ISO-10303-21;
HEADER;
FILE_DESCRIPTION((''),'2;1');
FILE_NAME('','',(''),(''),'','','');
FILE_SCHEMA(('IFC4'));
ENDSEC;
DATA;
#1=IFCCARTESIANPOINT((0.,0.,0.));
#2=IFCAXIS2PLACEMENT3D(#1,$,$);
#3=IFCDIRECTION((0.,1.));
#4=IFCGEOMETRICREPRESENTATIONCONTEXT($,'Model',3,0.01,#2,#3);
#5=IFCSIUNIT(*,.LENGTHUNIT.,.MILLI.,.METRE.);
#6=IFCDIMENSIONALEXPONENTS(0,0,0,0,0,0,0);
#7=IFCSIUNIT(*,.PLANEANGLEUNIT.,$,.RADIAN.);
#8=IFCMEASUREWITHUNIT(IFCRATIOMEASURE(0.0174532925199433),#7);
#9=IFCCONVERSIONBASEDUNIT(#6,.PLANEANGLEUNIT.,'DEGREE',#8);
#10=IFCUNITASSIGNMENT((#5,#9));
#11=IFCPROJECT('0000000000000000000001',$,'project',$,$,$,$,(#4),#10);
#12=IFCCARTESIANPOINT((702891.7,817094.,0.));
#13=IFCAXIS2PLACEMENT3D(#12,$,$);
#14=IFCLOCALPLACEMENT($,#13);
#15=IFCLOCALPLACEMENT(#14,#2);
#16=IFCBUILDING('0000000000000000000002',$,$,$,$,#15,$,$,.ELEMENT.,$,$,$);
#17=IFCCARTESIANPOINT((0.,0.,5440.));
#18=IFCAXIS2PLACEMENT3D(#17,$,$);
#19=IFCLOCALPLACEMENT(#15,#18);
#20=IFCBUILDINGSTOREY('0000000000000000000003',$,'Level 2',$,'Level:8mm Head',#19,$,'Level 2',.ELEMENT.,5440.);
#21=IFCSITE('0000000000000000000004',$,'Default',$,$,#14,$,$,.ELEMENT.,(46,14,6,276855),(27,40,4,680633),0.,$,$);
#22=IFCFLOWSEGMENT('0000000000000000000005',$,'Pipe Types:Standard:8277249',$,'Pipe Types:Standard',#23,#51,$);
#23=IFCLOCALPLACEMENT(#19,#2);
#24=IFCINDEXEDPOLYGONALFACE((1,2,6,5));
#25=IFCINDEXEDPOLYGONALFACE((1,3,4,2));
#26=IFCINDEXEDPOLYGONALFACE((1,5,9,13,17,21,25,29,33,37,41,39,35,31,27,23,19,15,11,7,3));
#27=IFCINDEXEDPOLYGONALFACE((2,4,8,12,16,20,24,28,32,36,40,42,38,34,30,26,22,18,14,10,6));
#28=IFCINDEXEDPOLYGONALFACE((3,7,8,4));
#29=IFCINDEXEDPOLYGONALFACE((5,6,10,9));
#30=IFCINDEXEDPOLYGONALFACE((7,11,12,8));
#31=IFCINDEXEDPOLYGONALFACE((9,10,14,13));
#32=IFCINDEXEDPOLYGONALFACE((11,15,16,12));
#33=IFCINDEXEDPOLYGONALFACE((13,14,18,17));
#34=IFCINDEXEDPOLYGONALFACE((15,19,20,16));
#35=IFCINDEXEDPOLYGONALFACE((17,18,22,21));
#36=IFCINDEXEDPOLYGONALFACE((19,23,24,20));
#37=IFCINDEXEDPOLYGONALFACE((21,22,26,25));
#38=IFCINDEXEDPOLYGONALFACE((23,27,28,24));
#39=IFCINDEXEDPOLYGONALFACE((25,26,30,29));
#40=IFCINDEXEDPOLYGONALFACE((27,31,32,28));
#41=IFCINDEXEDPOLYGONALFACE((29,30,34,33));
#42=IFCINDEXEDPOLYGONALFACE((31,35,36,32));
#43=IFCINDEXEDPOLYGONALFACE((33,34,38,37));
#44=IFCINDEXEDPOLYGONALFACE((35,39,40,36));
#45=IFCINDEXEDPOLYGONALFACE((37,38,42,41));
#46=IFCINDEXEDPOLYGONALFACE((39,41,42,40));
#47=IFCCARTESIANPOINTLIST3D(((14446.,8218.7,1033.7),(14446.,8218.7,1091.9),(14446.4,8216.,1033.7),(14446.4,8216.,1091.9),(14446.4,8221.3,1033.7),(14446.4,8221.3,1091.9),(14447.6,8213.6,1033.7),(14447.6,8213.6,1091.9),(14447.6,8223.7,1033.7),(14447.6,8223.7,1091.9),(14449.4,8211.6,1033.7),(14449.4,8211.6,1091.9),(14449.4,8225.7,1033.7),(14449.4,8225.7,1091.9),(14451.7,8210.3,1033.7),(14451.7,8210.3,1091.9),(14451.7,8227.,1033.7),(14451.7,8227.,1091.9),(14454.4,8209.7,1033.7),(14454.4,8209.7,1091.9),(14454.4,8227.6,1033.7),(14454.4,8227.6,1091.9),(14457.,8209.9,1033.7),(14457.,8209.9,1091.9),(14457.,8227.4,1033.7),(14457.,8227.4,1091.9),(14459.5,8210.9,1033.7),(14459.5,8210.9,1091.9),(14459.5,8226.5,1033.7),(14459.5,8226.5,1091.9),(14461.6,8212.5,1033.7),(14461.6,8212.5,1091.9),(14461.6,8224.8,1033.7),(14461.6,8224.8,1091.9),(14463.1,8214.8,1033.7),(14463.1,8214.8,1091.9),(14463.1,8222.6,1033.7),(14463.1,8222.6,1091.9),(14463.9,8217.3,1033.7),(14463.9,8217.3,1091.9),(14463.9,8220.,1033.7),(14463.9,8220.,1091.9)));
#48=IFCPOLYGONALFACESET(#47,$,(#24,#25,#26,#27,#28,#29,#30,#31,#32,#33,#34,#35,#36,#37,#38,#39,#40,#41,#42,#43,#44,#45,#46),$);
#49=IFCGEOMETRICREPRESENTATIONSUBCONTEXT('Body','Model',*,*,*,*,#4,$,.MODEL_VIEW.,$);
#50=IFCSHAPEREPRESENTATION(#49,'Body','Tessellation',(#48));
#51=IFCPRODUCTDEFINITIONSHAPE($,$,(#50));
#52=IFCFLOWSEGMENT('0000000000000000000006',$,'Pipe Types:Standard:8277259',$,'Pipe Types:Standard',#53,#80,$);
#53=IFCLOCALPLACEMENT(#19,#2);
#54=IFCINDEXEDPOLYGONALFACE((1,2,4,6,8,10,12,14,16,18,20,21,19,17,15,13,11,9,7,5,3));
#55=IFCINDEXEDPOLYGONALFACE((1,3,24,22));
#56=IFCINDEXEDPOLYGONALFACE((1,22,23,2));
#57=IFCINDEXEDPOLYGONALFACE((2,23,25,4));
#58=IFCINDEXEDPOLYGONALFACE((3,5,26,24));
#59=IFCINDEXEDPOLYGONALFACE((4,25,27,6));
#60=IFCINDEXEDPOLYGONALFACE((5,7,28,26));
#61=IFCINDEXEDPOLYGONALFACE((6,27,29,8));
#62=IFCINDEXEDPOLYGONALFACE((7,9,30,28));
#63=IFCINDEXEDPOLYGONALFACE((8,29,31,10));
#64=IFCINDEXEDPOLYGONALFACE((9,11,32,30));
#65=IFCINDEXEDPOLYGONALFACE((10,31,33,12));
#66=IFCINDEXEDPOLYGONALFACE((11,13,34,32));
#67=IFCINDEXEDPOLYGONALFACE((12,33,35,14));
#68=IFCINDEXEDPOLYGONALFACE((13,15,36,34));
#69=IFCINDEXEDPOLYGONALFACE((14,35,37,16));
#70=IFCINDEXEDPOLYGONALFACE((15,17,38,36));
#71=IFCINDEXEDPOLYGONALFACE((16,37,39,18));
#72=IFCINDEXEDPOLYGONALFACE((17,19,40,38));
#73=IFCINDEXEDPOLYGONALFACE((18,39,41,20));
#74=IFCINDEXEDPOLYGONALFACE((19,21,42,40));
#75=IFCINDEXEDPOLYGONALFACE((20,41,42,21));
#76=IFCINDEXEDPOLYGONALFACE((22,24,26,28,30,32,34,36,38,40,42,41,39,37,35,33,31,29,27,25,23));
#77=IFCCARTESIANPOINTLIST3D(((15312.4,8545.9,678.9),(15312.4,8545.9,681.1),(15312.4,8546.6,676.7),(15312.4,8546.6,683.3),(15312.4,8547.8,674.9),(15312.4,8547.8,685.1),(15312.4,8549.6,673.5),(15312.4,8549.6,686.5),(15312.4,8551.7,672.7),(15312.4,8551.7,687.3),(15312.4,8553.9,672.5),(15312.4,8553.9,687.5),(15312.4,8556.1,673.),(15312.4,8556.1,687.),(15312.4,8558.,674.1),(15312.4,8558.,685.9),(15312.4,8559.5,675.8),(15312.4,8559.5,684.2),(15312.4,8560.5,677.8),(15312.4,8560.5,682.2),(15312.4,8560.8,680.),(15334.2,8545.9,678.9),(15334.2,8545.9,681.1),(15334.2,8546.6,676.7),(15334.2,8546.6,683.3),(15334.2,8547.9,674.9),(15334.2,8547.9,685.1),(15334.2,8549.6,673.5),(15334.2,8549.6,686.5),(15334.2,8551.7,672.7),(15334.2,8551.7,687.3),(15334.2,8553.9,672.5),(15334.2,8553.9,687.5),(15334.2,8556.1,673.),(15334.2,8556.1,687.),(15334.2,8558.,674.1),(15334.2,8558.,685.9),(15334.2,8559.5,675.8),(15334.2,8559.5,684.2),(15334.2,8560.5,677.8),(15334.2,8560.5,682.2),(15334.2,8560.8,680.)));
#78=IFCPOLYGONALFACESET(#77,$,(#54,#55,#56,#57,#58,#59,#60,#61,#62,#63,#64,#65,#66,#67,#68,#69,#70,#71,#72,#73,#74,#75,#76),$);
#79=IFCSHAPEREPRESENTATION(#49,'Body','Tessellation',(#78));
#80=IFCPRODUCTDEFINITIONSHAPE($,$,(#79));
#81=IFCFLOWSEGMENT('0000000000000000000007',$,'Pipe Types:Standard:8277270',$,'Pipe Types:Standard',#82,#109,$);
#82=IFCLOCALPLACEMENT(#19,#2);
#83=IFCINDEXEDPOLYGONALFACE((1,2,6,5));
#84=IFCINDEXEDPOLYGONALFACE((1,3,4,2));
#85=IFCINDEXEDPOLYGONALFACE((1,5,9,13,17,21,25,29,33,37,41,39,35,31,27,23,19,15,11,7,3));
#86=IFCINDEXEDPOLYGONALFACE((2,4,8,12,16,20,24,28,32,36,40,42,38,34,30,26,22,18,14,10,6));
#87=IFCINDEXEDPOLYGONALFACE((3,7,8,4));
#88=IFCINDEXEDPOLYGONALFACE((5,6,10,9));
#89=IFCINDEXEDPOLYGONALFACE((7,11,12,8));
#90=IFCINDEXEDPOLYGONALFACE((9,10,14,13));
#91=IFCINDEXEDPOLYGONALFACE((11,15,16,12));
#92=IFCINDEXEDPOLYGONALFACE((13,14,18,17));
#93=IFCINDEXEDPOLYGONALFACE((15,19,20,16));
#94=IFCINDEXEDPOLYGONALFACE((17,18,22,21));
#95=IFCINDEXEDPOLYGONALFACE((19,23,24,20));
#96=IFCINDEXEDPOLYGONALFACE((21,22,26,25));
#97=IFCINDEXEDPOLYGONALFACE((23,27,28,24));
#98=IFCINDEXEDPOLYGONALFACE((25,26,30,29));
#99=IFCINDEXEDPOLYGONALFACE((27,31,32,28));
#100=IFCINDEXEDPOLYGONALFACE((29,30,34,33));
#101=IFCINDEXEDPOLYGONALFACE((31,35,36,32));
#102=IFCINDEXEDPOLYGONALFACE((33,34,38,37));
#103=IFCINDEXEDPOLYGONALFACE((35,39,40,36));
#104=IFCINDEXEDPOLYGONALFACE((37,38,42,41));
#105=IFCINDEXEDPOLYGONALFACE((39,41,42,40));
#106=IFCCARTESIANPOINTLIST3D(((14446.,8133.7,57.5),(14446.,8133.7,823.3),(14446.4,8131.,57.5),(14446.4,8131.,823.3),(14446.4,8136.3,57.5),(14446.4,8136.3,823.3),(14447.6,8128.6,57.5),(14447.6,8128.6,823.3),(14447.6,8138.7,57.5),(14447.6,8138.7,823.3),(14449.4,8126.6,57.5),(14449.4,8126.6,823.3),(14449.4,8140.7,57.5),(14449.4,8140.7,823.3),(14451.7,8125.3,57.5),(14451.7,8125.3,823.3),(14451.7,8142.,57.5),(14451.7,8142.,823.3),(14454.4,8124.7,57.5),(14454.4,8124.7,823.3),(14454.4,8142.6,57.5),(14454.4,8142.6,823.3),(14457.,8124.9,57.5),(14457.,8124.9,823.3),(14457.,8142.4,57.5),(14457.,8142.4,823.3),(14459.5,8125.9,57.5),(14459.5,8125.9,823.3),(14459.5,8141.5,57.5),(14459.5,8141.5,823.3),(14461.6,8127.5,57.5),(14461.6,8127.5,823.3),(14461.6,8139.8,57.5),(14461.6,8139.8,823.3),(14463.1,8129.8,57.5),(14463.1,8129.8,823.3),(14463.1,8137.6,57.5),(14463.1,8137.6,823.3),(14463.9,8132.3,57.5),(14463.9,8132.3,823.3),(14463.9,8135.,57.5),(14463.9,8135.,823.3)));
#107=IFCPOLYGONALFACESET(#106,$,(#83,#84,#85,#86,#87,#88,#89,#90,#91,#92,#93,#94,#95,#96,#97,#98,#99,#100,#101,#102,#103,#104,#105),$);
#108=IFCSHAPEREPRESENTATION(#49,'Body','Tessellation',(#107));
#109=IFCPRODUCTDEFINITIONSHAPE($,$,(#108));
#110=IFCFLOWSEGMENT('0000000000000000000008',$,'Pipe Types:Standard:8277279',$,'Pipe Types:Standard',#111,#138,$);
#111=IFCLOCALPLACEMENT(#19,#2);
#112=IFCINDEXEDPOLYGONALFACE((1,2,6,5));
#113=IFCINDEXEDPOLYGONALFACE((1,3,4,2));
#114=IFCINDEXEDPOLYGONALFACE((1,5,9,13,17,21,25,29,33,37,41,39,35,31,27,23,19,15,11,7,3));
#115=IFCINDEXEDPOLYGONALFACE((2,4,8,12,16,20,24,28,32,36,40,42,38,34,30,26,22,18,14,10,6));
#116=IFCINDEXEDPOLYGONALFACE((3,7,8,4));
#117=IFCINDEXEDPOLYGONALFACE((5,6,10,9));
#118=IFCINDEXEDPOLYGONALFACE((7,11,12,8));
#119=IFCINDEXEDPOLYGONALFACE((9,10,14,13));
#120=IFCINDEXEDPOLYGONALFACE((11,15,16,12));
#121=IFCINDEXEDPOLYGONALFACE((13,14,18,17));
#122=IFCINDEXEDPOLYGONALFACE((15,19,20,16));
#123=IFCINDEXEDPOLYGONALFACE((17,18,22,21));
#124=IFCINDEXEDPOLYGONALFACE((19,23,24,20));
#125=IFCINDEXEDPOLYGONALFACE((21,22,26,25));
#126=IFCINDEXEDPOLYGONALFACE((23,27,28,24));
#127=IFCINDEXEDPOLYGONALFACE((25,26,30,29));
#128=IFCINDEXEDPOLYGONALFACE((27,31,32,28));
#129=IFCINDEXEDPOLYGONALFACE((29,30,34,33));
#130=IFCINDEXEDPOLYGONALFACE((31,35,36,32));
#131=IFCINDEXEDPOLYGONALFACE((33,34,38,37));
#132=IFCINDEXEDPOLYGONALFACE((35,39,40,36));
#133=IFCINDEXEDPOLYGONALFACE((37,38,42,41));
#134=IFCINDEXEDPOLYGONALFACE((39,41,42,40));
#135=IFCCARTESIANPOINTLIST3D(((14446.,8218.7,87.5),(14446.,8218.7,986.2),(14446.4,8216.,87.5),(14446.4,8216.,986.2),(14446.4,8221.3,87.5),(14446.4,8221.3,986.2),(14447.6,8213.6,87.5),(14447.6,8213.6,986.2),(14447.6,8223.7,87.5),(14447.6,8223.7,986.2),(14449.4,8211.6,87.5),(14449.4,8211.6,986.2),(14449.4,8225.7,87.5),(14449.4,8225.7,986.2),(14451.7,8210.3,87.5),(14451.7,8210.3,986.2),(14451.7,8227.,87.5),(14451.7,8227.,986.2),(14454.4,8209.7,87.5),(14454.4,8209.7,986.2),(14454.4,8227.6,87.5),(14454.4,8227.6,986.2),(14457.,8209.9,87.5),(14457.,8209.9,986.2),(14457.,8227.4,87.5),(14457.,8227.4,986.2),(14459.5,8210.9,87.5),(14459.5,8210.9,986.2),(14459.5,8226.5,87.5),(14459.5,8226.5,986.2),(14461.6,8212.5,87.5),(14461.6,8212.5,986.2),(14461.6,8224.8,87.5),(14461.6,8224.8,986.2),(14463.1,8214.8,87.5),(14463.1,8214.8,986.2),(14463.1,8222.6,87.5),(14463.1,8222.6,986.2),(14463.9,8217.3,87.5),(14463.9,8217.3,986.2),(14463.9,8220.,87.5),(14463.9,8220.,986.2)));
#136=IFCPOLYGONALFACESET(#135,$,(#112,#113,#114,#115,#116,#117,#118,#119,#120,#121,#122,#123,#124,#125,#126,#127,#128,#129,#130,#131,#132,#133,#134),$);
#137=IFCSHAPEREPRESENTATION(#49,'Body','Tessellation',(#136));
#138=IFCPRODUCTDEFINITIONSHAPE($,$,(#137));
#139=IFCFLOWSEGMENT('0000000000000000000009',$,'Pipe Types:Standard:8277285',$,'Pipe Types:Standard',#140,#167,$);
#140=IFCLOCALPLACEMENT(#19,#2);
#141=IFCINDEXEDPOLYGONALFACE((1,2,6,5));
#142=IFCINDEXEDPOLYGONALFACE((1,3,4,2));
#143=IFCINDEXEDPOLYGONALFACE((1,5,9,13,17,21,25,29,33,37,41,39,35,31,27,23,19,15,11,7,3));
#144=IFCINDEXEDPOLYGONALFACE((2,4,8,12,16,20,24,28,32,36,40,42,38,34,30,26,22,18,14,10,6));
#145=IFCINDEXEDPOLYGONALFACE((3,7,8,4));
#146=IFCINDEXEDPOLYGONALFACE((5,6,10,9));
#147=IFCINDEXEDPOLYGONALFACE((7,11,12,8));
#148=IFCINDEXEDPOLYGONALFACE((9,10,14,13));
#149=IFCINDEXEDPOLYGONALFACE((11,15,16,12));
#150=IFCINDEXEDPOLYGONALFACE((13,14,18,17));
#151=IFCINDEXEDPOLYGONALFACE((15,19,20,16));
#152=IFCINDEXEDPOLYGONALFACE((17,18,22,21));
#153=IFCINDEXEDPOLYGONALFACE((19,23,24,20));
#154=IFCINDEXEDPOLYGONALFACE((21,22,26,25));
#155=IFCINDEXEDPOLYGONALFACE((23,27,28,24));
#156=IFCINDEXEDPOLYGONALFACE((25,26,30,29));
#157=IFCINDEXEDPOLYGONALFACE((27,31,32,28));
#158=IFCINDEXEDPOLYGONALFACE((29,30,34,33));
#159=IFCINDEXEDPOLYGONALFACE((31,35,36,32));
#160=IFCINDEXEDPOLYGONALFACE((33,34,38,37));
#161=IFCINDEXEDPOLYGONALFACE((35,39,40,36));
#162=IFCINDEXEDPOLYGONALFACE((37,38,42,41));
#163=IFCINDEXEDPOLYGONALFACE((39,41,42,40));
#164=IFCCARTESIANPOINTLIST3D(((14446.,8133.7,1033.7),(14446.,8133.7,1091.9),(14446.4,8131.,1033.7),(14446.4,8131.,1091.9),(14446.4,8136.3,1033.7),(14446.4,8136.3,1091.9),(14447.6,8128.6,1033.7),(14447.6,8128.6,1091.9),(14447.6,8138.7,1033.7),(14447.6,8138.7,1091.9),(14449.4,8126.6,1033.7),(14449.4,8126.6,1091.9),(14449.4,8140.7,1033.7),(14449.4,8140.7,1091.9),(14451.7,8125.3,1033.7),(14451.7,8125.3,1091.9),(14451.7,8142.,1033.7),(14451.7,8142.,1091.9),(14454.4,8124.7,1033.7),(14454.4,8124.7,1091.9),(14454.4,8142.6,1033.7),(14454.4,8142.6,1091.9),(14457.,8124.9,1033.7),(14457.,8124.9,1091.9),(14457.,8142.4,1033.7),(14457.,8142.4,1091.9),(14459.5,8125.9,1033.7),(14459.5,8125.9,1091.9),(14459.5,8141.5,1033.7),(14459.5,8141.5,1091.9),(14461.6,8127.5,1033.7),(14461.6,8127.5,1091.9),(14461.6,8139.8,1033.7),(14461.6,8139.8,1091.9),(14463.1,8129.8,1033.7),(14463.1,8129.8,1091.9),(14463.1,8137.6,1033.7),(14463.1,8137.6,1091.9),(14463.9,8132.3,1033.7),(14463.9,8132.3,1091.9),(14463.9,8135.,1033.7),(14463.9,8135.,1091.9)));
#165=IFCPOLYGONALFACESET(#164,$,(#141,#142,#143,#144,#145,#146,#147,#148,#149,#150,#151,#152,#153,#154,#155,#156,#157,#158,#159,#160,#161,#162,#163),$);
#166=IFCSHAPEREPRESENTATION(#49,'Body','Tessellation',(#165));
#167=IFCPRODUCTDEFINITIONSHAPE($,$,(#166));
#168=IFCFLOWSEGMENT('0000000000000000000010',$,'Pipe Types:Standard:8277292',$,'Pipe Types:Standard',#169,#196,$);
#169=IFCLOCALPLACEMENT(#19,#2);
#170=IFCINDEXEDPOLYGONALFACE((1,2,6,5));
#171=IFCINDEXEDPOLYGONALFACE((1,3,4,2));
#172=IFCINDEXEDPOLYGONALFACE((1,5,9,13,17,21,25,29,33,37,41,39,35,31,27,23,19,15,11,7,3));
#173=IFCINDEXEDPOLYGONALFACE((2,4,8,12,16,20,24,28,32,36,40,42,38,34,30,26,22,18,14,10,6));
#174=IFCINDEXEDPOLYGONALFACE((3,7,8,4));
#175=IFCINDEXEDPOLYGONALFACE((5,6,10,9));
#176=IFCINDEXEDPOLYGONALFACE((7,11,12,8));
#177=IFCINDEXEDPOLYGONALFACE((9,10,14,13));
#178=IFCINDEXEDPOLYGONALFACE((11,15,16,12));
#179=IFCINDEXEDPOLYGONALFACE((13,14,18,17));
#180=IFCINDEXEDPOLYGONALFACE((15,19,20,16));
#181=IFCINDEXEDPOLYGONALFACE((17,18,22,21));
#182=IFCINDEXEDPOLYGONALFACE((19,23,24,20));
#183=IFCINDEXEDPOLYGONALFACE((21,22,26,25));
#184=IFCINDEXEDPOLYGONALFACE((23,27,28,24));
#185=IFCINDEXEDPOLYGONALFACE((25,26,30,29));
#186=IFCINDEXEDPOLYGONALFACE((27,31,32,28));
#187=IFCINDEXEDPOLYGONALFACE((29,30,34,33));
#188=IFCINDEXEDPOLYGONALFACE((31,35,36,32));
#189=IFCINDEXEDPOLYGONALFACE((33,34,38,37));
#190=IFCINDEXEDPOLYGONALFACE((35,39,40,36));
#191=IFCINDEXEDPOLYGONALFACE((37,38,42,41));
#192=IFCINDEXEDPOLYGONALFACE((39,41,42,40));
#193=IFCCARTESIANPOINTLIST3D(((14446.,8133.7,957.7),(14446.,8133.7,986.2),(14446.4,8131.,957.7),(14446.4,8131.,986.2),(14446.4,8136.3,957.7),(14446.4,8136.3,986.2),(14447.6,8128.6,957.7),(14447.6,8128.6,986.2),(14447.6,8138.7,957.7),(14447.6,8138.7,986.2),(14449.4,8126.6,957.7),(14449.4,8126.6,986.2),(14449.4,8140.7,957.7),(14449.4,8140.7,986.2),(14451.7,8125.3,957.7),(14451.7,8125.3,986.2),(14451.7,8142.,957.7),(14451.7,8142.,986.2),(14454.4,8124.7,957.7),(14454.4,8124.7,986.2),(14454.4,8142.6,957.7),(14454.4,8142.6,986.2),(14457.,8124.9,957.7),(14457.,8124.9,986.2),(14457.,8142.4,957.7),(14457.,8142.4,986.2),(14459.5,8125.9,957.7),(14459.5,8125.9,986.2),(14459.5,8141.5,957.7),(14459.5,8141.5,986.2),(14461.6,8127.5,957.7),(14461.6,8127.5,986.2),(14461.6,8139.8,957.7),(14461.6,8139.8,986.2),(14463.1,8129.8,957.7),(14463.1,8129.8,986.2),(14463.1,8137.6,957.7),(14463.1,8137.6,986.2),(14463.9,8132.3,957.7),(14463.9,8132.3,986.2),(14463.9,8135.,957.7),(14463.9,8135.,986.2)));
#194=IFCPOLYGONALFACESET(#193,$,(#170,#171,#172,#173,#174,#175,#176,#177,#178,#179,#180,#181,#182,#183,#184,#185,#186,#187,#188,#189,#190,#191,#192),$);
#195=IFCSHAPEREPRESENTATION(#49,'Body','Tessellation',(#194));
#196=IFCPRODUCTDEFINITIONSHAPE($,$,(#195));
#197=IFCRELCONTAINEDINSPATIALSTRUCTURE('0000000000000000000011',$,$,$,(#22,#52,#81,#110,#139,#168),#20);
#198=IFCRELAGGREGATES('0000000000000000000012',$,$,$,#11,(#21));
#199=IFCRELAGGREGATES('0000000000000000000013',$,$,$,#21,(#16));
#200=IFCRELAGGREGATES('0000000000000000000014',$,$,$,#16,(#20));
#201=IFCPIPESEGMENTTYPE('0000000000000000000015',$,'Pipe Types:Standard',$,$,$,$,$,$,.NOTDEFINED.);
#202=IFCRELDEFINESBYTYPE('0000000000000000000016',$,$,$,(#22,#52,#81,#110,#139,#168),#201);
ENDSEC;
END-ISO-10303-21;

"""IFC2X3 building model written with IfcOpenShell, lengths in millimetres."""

from ifc_helpers import new_model, entity, si_unit, converted_unit, direction, frame, frame_2d, origin, origin_2d_with_axis, place, context, subcontext, project, spatial, circle, extrude, type_object, element, save


model = new_model("IFC2X3")

# Units and contexts
model_context = context("Model", 3, precision=0.01, world=origin(), true_north=direction((0.0, 1.0)))
body_context = subcontext(model_context, "Body", "Model", "MODEL_VIEW")
ifc_project = project(units=[si_unit("LENGTHUNIT", "METRE", prefix="MILLI"), converted_unit("PLANEANGLEUNIT", "DEGREE", entity("IfcRatioMeasure", 0.0174532925199433), si_unit("PLANEANGLEUNIT", "RADIAN"), dimensions=[0, 0, 0, 0, 0, 0, 0])], contexts=[model_context])

# Site, building, storey
site_placement = place(None, frame((702891.7, 817094.0, 0.0)))
site = spatial("IfcSite", under=ifc_project, at=site_placement, Name="Default", CompositionType="ELEMENT", RefLatitude=(46, 14, 6, 276855), RefLongitude=(27, 40, 4, 680633), RefElevation=0.0)
building_placement = place(site_placement, origin())
building = spatial("IfcBuilding", under=site, at=building_placement, CompositionType="ELEMENT")
storey_placement = place(building_placement, frame((0.0, 0.0, 5440.0)))
storey = spatial("IfcBuildingStorey", under=building, at=storey_placement, Name="Level 2", ObjectType="Level:8mm Head", LongName="Level 2", CompositionType="ELEMENT", Elevation=5440.0)

# Flow segments
pipe_segment_type = type_object("IfcPipeSegmentType", Name="Pipe Types:Standard", PredefinedType="NOTDEFINED")
flow_segment_1_placement = place(storey_placement, origin())
element("IfcFlowSegment", 1, at=flow_segment_1_placement, inside=storey, type_object=pipe_segment_type, Name="Pipe Types:Standard:8277249", ObjectType="Pipe Types:Standard", context=body_context, shape_type="SweptSolid", body=[
    extrude(circle(Radius=9.0, at=frame_2d((0.0, 0.0), x_axis=(1.0, 0.0))), frame((14455.0, 8218.7, 1033.7), z_axis=(0.0, 0.0, 1.0), x_axis=(-1.0, 0.0, 0.0)), (0.0, 0.0, 1.0), 58.1),
])
flow_segment_2_placement = place(storey_placement, origin())
element("IfcFlowSegment", 2, at=flow_segment_2_placement, inside=storey, type_object=pipe_segment_type, Name="Pipe Types:Standard:8277259", ObjectType="Pipe Types:Standard", context=body_context, shape_type="SweptSolid", body=[
    extrude(circle(Radius=7.5, at=origin_2d_with_axis()), frame((15312.4, 8553.3, 680.0), z_axis=(1.0, 0.000154, 0.0), x_axis=(-0.000154, 1.0, 0.0)), (0.0, 0.0, 1.0), 21.8),
])
flow_segment_3_placement = place(storey_placement, origin())
element("IfcFlowSegment", 3, at=flow_segment_3_placement, inside=storey, type_object=pipe_segment_type, Name="Pipe Types:Standard:8277270", ObjectType="Pipe Types:Standard", context=body_context, shape_type="SweptSolid", body=[
    extrude(circle(Radius=9.0, at=origin_2d_with_axis()), frame((14455.0, 8133.7, 57.5), z_axis=(0.0, 0.0, 1.0), x_axis=(-1.0, 0.0, 0.0)), (0.0, 0.0, 1.0), 765.8),
])
flow_segment_4_placement = place(storey_placement, origin())
element("IfcFlowSegment", 4, at=flow_segment_4_placement, inside=storey, type_object=pipe_segment_type, Name="Pipe Types:Standard:8277279", ObjectType="Pipe Types:Standard", context=body_context, shape_type="SweptSolid", body=[
    extrude(circle(Radius=9.0, at=origin_2d_with_axis()), frame((14455.0, 8218.7, 87.5), z_axis=(0.0, 0.0, 1.0), x_axis=(-1.0, 0.0, 0.0)), (0.0, 0.0, 1.0), 898.7),
])
flow_segment_5_placement = place(storey_placement, origin())
element("IfcFlowSegment", 5, at=flow_segment_5_placement, inside=storey, type_object=pipe_segment_type, Name="Pipe Types:Standard:8277285", ObjectType="Pipe Types:Standard", context=body_context, shape_type="SweptSolid", body=[
    extrude(circle(Radius=9.0, at=frame_2d((0.0, 0.0), x_axis=(1.0, 0.0))), frame((14455.0, 8133.7, 1033.7), z_axis=(0.0, 0.0, 1.0), x_axis=(-1.0, 0.0, 0.0)), (0.0, 0.0, 1.0), 58.1),
])
flow_segment_6_placement = place(storey_placement, origin())
element("IfcFlowSegment", 6, at=flow_segment_6_placement, inside=storey, type_object=pipe_segment_type, Name="Pipe Types:Standard:8277292", ObjectType="Pipe Types:Standard", context=body_context, shape_type="SweptSolid", body=[
    extrude(circle(Radius=9.0, at=origin_2d_with_axis()), frame((14455.0, 8133.7, 957.7), z_axis=(0.0, 0.0, 1.0), x_axis=(-1.0, 0.0, 0.0)), (0.0, 0.0, 1.0), 28.6),
])

save(model, "model.ifc")
